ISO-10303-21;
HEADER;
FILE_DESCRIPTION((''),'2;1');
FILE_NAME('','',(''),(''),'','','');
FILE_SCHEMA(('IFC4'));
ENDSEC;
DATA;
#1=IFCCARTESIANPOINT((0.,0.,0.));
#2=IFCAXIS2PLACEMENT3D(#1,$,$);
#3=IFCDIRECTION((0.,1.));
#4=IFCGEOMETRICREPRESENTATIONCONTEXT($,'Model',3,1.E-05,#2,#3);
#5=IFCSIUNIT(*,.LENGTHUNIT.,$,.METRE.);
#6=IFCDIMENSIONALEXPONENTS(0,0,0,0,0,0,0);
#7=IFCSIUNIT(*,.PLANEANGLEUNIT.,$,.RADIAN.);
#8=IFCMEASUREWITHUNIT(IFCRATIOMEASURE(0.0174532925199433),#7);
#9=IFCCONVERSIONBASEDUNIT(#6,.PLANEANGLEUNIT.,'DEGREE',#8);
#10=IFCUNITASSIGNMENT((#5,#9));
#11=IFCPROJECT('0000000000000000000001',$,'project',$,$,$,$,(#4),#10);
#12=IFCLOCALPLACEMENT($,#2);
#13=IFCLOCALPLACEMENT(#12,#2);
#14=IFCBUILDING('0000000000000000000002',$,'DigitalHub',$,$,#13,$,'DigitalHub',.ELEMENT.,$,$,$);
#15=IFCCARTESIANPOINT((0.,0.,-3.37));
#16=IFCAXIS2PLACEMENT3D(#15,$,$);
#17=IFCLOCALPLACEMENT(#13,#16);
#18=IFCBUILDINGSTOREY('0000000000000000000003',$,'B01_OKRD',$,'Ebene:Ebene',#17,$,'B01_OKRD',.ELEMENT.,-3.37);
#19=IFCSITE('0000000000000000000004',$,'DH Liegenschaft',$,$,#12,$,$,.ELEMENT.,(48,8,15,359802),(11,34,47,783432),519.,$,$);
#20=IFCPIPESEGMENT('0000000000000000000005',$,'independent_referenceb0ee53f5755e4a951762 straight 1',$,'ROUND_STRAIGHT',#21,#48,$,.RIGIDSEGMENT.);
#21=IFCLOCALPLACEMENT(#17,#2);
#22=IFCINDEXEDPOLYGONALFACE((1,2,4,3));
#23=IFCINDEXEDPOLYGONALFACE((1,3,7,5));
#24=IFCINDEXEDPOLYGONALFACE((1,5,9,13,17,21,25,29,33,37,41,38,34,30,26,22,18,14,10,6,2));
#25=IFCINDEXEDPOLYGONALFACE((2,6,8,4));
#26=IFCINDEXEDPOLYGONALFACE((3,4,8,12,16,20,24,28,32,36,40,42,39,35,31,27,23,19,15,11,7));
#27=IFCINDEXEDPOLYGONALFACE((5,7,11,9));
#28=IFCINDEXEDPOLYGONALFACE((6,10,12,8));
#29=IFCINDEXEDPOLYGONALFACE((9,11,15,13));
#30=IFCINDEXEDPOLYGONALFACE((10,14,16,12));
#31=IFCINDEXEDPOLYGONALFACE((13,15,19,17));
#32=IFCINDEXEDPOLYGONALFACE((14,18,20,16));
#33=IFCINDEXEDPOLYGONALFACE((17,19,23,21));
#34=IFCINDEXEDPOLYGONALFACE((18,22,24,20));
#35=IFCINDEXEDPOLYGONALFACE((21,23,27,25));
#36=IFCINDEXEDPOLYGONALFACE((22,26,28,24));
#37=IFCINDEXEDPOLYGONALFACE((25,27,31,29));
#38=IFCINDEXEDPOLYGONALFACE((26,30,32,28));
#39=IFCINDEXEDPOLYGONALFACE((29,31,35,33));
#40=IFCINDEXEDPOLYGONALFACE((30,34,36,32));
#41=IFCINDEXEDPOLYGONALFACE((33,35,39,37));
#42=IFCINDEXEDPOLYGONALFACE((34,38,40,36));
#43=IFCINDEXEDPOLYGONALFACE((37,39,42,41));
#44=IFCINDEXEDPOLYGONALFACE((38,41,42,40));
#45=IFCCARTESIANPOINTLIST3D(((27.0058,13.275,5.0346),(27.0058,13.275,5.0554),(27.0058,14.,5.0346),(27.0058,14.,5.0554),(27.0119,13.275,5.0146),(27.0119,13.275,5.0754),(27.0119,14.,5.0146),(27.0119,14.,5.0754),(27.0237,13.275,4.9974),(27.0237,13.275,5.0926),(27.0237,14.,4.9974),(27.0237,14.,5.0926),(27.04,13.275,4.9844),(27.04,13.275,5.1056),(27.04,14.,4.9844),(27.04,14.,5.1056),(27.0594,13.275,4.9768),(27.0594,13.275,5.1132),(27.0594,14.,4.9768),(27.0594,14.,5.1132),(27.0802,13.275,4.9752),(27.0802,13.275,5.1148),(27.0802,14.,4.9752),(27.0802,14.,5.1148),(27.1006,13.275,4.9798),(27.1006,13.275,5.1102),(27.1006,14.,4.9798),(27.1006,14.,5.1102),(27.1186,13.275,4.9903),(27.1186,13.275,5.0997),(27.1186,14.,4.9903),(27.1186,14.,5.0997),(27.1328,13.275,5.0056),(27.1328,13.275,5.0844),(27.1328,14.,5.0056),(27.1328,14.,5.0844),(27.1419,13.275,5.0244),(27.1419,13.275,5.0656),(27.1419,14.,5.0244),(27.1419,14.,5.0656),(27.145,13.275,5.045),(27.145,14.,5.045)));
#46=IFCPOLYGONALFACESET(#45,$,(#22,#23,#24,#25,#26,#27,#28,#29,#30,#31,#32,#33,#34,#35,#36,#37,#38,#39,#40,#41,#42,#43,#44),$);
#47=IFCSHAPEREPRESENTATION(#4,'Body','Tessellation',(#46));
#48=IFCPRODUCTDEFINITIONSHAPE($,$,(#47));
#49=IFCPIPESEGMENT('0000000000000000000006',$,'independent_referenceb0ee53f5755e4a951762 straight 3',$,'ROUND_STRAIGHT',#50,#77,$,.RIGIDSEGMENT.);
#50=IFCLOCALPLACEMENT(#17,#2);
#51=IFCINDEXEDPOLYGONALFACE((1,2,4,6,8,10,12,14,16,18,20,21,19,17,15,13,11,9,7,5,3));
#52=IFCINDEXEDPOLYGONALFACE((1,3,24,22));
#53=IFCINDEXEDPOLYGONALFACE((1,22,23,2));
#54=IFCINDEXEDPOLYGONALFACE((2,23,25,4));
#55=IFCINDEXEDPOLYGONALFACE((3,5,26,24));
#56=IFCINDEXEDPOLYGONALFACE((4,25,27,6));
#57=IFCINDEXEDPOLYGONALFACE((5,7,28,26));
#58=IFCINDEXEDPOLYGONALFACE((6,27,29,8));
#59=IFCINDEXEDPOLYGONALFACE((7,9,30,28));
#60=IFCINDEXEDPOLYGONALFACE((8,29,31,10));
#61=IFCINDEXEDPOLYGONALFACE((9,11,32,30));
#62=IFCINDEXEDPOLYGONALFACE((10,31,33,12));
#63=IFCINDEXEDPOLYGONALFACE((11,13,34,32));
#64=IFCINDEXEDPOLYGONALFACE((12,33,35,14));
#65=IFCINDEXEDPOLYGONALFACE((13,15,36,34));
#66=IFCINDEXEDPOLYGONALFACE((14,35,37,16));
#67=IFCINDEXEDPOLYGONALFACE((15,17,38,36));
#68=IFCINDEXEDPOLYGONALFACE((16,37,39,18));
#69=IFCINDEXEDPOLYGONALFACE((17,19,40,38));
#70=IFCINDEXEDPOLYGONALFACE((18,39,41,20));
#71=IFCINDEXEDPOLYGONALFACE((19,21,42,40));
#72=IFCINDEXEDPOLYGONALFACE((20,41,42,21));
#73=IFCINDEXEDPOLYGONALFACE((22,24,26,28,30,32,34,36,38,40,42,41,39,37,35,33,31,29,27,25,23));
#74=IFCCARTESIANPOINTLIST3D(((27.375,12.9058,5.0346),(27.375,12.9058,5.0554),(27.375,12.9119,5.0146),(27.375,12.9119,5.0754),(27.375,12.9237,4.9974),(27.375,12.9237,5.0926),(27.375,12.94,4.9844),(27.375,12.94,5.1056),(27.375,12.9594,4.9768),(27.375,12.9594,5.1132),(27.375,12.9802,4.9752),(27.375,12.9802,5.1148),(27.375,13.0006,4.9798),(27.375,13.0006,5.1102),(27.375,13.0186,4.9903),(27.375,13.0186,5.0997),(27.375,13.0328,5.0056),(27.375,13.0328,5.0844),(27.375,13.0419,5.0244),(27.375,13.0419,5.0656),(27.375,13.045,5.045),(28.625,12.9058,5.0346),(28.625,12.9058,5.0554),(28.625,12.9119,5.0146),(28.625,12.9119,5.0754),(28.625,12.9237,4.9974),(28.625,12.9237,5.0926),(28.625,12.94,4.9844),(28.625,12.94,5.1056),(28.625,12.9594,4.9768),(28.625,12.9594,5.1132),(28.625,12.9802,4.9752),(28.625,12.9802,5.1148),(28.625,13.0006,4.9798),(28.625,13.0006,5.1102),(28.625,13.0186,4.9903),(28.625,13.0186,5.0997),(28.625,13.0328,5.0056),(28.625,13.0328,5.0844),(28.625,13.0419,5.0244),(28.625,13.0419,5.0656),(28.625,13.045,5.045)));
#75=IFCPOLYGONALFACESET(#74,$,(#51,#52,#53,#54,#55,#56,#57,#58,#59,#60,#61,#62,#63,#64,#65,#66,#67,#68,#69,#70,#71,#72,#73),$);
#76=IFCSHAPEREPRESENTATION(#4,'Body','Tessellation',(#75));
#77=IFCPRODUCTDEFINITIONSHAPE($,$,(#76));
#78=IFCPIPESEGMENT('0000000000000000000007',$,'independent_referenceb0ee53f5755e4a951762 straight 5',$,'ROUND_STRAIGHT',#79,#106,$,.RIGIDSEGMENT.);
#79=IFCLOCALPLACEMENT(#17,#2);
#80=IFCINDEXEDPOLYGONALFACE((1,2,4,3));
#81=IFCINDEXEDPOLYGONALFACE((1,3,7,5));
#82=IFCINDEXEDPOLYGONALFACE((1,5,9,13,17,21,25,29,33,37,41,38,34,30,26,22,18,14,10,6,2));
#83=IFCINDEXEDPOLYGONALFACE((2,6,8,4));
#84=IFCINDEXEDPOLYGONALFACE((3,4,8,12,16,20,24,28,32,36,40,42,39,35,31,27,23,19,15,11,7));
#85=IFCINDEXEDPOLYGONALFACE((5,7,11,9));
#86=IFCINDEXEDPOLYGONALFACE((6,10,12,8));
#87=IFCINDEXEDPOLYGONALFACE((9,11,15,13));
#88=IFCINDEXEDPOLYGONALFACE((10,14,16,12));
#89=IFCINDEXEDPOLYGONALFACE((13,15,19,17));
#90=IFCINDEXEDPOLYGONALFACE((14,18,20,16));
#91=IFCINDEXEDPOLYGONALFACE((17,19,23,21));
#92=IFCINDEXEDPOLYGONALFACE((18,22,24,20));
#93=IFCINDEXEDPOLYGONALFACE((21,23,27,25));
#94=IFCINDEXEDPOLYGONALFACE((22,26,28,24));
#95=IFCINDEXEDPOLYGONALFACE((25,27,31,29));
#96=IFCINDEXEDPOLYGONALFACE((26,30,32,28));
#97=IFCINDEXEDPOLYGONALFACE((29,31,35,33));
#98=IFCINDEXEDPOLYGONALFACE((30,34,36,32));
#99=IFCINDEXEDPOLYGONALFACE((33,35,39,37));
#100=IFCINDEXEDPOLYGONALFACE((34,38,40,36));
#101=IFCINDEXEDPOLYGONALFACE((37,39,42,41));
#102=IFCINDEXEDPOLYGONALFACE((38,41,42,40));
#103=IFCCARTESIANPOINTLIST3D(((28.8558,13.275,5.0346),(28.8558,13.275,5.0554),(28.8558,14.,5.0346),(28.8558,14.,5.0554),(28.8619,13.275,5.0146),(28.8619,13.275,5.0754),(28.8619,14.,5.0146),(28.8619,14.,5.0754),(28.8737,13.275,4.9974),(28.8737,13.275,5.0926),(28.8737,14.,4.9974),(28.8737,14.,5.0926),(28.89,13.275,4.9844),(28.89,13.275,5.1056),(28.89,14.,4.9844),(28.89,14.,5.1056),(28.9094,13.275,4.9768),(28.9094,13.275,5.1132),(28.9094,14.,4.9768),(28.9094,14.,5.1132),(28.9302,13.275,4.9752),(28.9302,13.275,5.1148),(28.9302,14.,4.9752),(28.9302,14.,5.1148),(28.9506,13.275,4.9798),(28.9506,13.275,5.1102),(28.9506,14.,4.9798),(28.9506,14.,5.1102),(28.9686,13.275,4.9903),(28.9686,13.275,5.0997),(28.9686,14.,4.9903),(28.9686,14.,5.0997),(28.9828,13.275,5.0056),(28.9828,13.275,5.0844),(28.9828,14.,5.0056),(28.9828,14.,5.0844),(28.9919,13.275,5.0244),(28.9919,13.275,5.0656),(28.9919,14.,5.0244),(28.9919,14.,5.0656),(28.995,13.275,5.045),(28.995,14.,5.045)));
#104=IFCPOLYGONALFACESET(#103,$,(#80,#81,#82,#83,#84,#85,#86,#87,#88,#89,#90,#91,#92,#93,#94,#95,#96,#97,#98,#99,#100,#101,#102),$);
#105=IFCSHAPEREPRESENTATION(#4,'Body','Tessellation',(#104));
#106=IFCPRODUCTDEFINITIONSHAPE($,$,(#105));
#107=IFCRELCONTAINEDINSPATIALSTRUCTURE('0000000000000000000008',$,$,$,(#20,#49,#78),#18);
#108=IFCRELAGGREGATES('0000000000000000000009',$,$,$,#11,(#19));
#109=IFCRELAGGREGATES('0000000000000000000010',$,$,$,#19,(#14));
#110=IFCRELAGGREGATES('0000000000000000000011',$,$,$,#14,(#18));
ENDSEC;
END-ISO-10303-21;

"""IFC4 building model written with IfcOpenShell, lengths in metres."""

from ifc_helpers import new_model, entity, si_unit, converted_unit, direction, frame, origin, origin_with_axes, origin_2d, place, context, project, spatial, circle, extrude, element, save


model = new_model("IFC4")

# Units and contexts
model_context = context("Model", 3, precision=1e-05, world=origin(), true_north=direction((0.0, 1.0)))
ifc_project = project(units=[si_unit("LENGTHUNIT", "METRE"), converted_unit("PLANEANGLEUNIT", "DEGREE", entity("IfcRatioMeasure", 0.0174532925199433), si_unit("PLANEANGLEUNIT", "RADIAN"), dimensions=[0, 0, 0, 0, 0, 0, 0])], contexts=[model_context])

# Site, building, storey
site_placement = place(None, frame((0.0, 0.0, 0.0)))
site = spatial("IfcSite", under=ifc_project, at=site_placement, Name="DH Liegenschaft", CompositionType="ELEMENT", RefLatitude=(48, 8, 15, 359802), RefLongitude=(11, 34, 47, 783432), RefElevation=519.0)
building_placement = place(site_placement, origin())
building = spatial("IfcBuilding", under=site, at=building_placement, Name="DigitalHub", LongName="DigitalHub", CompositionType="ELEMENT")
storey_placement = place(building_placement, frame((0.0, 0.0, -3.37)))
storey = spatial("IfcBuildingStorey", under=building, at=storey_placement, Name="B01_OKRD", ObjectType="Ebene:Ebene", LongName="B01_OKRD", CompositionType="ELEMENT", Elevation=-3.37)

# Pipe segment
pipe_segment_1_placement = place(None, origin_with_axes())
element("IfcPipeSegment", 1, at=pipe_segment_1_placement, inside=storey, Name="independent_referenceb0ee53f5755e4a951762 straight 1", ObjectType="ROUND_STRAIGHT", PredefinedType="RIGIDSEGMENT", context=model_context, shape_type="SweptSolid", body=[
    extrude(circle(Radius=0.07, at=origin_2d()), frame((27.075, 14.0, 1.675), z_axis=(0.0, -1.0, 0.0), x_axis=(1.0, 0.0, 0.0)), (0.0, 0.0, 1.0), 0.725),
])

# Pipe segment
pipe_segment_2_placement = place(None, origin_with_axes())
element("IfcPipeSegment", 2, at=pipe_segment_2_placement, inside=storey, Name="independent_referenceb0ee53f5755e4a951762 straight 3", ObjectType="ROUND_STRAIGHT", PredefinedType="RIGIDSEGMENT", context=model_context, shape_type="SweptSolid", body=[
    extrude(circle(Radius=0.07, at=origin_2d()), frame((27.375, 12.975, 1.675), z_axis=(1.0, 0.0, 0.0), x_axis=(0.0, 1.0, 0.0)), (0.0, 0.0, 1.0), 1.25),
])

# Pipe segment
pipe_segment_3_placement = place(None, origin_with_axes())
element("IfcPipeSegment", 3, at=pipe_segment_3_placement, inside=storey, Name="independent_referenceb0ee53f5755e4a951762 straight 5", ObjectType="ROUND_STRAIGHT", PredefinedType="RIGIDSEGMENT", context=model_context, shape_type="SweptSolid", body=[
    extrude(circle(Radius=0.07, at=origin_2d()), frame((28.925, 13.275, 1.675), z_axis=(0.0, 1.0, 0.0), x_axis=(1.0, 0.0, 0.0)), (0.0, 0.0, 1.0), 0.725),
])

save(model, "model.ifc")
